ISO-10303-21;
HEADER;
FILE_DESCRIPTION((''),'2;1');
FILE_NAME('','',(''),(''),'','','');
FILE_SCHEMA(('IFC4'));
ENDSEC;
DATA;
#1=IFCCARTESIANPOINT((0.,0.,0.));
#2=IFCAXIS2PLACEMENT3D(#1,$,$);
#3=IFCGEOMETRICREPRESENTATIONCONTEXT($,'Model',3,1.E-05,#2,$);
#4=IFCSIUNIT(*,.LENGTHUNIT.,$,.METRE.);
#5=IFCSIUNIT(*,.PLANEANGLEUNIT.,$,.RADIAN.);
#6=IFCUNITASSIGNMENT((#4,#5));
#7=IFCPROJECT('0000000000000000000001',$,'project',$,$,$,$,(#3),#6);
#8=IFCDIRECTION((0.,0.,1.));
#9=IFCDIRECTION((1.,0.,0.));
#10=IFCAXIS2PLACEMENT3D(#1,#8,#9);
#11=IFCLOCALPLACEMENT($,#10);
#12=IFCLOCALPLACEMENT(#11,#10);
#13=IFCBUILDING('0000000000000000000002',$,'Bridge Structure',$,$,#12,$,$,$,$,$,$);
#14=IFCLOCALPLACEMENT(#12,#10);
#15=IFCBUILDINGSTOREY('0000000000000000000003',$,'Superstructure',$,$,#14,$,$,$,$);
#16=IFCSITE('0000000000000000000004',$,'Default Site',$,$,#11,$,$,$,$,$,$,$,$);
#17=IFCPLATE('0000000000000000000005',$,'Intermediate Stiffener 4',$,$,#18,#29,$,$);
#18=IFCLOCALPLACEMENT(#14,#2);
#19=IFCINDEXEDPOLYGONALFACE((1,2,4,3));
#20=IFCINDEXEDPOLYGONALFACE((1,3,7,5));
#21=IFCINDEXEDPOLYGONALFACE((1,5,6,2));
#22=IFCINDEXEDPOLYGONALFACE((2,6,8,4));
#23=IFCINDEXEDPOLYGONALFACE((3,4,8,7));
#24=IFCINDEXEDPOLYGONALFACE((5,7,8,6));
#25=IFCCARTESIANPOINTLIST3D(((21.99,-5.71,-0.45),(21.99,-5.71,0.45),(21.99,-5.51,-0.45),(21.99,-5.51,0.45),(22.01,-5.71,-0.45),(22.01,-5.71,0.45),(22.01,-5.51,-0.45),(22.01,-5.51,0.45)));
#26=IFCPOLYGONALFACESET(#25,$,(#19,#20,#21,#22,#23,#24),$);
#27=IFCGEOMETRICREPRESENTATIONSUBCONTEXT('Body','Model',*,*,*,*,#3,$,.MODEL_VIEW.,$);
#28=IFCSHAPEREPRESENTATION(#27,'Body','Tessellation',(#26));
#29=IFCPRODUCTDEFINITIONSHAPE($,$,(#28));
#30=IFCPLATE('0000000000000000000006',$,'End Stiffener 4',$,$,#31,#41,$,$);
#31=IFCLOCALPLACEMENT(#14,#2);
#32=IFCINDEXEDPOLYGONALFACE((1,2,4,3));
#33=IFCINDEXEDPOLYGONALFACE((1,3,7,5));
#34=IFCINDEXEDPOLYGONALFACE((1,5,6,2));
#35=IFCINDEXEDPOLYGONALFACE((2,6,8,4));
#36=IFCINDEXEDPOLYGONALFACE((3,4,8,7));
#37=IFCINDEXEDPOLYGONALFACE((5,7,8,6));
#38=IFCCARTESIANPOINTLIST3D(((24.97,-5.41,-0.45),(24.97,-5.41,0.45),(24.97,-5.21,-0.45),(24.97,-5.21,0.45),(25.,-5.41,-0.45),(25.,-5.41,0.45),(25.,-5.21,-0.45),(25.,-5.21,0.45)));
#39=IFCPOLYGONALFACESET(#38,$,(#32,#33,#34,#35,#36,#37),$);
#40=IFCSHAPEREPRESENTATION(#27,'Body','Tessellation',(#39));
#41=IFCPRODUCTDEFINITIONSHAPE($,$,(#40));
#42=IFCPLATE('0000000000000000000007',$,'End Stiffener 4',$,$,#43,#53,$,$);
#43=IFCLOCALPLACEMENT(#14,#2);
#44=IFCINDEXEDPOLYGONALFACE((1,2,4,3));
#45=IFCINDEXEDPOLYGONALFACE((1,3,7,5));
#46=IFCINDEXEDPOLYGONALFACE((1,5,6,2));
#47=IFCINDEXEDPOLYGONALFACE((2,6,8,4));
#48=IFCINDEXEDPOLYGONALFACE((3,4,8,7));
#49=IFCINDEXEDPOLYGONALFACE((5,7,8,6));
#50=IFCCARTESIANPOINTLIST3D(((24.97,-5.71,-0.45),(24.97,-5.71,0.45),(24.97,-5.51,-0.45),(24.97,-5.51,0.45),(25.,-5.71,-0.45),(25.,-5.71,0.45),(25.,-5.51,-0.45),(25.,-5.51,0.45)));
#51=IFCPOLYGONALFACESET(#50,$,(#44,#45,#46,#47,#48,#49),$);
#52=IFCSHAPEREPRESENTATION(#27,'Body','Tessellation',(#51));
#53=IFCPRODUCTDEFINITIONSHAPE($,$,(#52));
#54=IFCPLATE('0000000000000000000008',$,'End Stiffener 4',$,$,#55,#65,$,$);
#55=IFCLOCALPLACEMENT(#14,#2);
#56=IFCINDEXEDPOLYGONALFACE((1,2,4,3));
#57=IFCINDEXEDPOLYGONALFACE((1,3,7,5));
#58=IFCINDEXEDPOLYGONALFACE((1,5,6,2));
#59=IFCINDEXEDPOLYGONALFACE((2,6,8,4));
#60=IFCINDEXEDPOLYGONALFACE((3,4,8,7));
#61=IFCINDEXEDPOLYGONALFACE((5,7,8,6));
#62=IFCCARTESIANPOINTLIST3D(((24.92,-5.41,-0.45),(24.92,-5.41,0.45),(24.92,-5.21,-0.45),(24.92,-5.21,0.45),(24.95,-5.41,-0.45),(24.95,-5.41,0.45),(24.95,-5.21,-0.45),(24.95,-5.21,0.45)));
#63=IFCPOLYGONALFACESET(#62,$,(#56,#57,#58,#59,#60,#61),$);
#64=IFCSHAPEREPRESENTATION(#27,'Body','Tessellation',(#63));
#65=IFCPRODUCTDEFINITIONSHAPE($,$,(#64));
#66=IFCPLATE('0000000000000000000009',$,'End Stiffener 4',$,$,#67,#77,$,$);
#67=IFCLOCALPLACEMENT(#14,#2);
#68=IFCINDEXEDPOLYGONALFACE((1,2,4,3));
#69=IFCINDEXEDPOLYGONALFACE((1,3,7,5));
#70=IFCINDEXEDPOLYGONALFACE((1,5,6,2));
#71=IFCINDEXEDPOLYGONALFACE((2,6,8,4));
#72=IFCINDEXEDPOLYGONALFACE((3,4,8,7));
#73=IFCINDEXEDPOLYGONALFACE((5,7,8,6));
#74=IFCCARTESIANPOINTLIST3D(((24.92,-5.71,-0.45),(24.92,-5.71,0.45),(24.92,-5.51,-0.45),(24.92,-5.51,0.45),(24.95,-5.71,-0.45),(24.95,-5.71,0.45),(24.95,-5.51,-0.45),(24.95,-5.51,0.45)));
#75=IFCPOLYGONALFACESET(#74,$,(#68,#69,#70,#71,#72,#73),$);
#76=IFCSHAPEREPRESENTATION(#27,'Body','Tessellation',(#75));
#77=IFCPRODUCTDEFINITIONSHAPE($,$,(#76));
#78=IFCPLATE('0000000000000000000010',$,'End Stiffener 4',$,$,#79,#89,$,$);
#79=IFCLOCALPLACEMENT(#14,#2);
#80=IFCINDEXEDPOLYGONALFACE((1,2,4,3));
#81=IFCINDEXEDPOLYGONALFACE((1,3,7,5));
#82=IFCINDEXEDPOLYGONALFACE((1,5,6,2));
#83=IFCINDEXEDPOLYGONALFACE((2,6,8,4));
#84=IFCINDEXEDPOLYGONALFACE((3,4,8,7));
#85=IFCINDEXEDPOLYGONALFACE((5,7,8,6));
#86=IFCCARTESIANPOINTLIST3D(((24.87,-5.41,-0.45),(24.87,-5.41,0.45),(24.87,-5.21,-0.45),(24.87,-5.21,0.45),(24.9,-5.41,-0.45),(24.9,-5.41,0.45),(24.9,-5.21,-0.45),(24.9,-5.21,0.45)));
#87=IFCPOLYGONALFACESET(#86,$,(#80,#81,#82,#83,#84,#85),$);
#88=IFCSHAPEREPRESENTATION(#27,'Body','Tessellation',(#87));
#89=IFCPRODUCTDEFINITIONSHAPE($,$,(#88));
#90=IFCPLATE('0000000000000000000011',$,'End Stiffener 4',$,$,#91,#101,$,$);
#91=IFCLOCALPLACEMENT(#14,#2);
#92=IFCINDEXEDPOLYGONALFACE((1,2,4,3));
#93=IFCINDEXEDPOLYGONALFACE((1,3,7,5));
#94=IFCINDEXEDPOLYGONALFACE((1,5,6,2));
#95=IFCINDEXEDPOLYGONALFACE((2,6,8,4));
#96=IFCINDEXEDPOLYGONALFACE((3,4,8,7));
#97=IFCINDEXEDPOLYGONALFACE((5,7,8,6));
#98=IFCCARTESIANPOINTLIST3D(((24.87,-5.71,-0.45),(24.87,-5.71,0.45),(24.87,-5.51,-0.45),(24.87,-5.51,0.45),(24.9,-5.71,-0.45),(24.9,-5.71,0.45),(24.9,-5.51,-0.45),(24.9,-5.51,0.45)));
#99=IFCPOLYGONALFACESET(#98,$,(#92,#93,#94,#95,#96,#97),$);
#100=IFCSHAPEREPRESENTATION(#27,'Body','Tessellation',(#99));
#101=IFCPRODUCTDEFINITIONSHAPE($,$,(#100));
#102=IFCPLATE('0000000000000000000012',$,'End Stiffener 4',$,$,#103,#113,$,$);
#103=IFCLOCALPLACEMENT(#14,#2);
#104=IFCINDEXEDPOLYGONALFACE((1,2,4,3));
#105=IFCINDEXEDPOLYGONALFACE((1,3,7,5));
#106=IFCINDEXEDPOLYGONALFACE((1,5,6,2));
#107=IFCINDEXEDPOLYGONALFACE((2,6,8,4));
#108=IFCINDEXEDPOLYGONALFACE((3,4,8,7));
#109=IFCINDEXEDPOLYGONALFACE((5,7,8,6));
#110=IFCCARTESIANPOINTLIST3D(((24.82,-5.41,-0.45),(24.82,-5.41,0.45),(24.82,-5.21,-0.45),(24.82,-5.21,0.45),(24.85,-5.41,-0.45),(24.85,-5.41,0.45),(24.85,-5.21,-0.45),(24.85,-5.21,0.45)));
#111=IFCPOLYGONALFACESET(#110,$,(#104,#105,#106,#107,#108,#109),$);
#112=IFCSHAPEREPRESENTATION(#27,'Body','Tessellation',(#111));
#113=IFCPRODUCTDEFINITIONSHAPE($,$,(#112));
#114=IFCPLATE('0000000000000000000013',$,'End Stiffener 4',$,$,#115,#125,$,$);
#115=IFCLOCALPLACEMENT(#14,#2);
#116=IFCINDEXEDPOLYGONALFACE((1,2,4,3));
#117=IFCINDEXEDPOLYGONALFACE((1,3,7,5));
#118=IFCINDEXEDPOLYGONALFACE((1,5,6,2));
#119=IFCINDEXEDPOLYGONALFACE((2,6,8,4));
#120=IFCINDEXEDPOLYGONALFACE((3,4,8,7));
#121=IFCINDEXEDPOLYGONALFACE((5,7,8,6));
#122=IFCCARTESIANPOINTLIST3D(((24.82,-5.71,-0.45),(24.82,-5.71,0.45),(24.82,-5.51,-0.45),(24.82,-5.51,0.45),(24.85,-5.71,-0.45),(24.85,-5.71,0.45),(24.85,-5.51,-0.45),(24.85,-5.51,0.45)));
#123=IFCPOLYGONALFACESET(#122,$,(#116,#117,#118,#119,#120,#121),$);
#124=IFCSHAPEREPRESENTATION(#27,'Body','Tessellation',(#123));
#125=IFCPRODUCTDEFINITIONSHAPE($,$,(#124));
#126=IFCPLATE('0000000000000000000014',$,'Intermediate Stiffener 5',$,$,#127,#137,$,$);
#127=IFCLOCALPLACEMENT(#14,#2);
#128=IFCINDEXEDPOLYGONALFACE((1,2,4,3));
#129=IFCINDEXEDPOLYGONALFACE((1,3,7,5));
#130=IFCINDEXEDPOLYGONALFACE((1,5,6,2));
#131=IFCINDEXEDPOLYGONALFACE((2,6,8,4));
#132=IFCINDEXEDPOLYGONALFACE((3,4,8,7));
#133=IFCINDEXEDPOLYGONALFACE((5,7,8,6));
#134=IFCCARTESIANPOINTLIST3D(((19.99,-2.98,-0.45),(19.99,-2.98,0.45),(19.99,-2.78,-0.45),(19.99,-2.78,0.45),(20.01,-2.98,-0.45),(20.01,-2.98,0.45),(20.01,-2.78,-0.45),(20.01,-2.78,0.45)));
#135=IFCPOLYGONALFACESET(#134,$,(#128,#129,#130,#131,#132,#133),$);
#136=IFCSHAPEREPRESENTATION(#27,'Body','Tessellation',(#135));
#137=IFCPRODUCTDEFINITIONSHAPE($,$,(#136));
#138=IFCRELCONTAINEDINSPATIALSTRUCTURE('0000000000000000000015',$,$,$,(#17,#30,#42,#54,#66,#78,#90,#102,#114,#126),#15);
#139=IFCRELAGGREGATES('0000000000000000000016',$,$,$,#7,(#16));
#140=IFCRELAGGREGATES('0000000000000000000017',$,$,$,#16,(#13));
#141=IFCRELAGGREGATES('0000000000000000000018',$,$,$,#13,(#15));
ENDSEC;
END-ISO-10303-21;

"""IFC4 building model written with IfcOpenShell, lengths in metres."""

from ifc_helpers import new_model, si_unit, frame, origin, origin_with_axes, origin_2d_with_axis, place, context, subcontext, project, spatial, rectangle, extrude, element, save


model = new_model("IFC4")

# Units and contexts
model_context = context("Model", 3, precision=1e-05, world=origin())
body_context = subcontext(model_context, "Body", "Model", "MODEL_VIEW")
ifc_project = project(units=[si_unit("LENGTHUNIT", "METRE"), si_unit("PLANEANGLEUNIT", "RADIAN")], contexts=[model_context])

# Site, building, storey
site_placement = place(None, origin_with_axes())
site = spatial("IfcSite", under=ifc_project, at=site_placement, Name="Default Site")
building_placement = place(site_placement, origin_with_axes())
building = spatial("IfcBuilding", under=site, at=building_placement, Name="Bridge Structure")
storey_placement = place(building_placement, origin_with_axes())
storey = spatial("IfcBuildingStorey", under=building, at=storey_placement, Name="Superstructure")

# Plates
for number, where, z_axis, x_axis, name in (
    (1, (22.0, -5.61, -0.45), (0.0, 0.0, 1.0), (1.0, 0.0, 0.0), "Intermediate Stiffener 4"),
):
    element("IfcPlate", number, at=place(storey_placement, frame(where, z_axis=z_axis, x_axis=x_axis)), inside=storey, Name=name, context=body_context, shape_type="SweptSolid", body=[
        extrude(rectangle(XDim=0.02, YDim=0.2, at=origin_2d_with_axis()), origin_with_axes(), (0.0, 0.0, 1.0), 0.9),
    ])
for number, where, z_axis, x_axis, name in (
    (2, (24.985, -5.31, -0.45), (0.0, 0.0, 1.0), (1.0, 0.0, 0.0), "End Stiffener 4"),
    (3, (24.985, -5.61, -0.45), (0.0, 0.0, 1.0), (1.0, 0.0, 0.0), "End Stiffener 4"),
    (4, (24.935, -5.31, -0.45), (0.0, 0.0, 1.0), (1.0, 0.0, 0.0), "End Stiffener 4"),
    (5, (24.935, -5.61, -0.45), (0.0, 0.0, 1.0), (1.0, 0.0, 0.0), "End Stiffener 4"),
    (6, (24.885, -5.31, -0.45), (0.0, 0.0, 1.0), (1.0, 0.0, 0.0), "End Stiffener 4"),
    (7, (24.885, -5.61, -0.45), (0.0, 0.0, 1.0), (1.0, 0.0, 0.0), "End Stiffener 4"),
    (8, (24.835, -5.31, -0.45), (0.0, 0.0, 1.0), (1.0, 0.0, 0.0), "End Stiffener 4"),
    (9, (24.835, -5.61, -0.45), (0.0, 0.0, 1.0), (1.0, 0.0, 0.0), "End Stiffener 4"),
):
    element("IfcPlate", number, at=place(storey_placement, frame(where, z_axis=z_axis, x_axis=x_axis)), inside=storey, Name=name, context=body_context, shape_type="SweptSolid", body=[
        extrude(rectangle(XDim=0.03, YDim=0.2, at=origin_2d_with_axis()), origin_with_axes(), (0.0, 0.0, 1.0), 0.9),
    ])
plate_placement = place(storey_placement, frame((20.0, -2.88, -0.45), z_axis=(0.0, 0.0, 1.0), x_axis=(1.0, 0.0, 0.0)))
element("IfcPlate", 10, at=plate_placement, inside=storey, Name="Intermediate Stiffener 5", context=body_context, shape_type="SweptSolid", body=[
    extrude(rectangle(XDim=0.02, YDim=0.2, at=origin_2d_with_axis()), origin_with_axes(), (0.0, 0.0, 1.0), 0.9),
])

save(model, "model.ifc")
